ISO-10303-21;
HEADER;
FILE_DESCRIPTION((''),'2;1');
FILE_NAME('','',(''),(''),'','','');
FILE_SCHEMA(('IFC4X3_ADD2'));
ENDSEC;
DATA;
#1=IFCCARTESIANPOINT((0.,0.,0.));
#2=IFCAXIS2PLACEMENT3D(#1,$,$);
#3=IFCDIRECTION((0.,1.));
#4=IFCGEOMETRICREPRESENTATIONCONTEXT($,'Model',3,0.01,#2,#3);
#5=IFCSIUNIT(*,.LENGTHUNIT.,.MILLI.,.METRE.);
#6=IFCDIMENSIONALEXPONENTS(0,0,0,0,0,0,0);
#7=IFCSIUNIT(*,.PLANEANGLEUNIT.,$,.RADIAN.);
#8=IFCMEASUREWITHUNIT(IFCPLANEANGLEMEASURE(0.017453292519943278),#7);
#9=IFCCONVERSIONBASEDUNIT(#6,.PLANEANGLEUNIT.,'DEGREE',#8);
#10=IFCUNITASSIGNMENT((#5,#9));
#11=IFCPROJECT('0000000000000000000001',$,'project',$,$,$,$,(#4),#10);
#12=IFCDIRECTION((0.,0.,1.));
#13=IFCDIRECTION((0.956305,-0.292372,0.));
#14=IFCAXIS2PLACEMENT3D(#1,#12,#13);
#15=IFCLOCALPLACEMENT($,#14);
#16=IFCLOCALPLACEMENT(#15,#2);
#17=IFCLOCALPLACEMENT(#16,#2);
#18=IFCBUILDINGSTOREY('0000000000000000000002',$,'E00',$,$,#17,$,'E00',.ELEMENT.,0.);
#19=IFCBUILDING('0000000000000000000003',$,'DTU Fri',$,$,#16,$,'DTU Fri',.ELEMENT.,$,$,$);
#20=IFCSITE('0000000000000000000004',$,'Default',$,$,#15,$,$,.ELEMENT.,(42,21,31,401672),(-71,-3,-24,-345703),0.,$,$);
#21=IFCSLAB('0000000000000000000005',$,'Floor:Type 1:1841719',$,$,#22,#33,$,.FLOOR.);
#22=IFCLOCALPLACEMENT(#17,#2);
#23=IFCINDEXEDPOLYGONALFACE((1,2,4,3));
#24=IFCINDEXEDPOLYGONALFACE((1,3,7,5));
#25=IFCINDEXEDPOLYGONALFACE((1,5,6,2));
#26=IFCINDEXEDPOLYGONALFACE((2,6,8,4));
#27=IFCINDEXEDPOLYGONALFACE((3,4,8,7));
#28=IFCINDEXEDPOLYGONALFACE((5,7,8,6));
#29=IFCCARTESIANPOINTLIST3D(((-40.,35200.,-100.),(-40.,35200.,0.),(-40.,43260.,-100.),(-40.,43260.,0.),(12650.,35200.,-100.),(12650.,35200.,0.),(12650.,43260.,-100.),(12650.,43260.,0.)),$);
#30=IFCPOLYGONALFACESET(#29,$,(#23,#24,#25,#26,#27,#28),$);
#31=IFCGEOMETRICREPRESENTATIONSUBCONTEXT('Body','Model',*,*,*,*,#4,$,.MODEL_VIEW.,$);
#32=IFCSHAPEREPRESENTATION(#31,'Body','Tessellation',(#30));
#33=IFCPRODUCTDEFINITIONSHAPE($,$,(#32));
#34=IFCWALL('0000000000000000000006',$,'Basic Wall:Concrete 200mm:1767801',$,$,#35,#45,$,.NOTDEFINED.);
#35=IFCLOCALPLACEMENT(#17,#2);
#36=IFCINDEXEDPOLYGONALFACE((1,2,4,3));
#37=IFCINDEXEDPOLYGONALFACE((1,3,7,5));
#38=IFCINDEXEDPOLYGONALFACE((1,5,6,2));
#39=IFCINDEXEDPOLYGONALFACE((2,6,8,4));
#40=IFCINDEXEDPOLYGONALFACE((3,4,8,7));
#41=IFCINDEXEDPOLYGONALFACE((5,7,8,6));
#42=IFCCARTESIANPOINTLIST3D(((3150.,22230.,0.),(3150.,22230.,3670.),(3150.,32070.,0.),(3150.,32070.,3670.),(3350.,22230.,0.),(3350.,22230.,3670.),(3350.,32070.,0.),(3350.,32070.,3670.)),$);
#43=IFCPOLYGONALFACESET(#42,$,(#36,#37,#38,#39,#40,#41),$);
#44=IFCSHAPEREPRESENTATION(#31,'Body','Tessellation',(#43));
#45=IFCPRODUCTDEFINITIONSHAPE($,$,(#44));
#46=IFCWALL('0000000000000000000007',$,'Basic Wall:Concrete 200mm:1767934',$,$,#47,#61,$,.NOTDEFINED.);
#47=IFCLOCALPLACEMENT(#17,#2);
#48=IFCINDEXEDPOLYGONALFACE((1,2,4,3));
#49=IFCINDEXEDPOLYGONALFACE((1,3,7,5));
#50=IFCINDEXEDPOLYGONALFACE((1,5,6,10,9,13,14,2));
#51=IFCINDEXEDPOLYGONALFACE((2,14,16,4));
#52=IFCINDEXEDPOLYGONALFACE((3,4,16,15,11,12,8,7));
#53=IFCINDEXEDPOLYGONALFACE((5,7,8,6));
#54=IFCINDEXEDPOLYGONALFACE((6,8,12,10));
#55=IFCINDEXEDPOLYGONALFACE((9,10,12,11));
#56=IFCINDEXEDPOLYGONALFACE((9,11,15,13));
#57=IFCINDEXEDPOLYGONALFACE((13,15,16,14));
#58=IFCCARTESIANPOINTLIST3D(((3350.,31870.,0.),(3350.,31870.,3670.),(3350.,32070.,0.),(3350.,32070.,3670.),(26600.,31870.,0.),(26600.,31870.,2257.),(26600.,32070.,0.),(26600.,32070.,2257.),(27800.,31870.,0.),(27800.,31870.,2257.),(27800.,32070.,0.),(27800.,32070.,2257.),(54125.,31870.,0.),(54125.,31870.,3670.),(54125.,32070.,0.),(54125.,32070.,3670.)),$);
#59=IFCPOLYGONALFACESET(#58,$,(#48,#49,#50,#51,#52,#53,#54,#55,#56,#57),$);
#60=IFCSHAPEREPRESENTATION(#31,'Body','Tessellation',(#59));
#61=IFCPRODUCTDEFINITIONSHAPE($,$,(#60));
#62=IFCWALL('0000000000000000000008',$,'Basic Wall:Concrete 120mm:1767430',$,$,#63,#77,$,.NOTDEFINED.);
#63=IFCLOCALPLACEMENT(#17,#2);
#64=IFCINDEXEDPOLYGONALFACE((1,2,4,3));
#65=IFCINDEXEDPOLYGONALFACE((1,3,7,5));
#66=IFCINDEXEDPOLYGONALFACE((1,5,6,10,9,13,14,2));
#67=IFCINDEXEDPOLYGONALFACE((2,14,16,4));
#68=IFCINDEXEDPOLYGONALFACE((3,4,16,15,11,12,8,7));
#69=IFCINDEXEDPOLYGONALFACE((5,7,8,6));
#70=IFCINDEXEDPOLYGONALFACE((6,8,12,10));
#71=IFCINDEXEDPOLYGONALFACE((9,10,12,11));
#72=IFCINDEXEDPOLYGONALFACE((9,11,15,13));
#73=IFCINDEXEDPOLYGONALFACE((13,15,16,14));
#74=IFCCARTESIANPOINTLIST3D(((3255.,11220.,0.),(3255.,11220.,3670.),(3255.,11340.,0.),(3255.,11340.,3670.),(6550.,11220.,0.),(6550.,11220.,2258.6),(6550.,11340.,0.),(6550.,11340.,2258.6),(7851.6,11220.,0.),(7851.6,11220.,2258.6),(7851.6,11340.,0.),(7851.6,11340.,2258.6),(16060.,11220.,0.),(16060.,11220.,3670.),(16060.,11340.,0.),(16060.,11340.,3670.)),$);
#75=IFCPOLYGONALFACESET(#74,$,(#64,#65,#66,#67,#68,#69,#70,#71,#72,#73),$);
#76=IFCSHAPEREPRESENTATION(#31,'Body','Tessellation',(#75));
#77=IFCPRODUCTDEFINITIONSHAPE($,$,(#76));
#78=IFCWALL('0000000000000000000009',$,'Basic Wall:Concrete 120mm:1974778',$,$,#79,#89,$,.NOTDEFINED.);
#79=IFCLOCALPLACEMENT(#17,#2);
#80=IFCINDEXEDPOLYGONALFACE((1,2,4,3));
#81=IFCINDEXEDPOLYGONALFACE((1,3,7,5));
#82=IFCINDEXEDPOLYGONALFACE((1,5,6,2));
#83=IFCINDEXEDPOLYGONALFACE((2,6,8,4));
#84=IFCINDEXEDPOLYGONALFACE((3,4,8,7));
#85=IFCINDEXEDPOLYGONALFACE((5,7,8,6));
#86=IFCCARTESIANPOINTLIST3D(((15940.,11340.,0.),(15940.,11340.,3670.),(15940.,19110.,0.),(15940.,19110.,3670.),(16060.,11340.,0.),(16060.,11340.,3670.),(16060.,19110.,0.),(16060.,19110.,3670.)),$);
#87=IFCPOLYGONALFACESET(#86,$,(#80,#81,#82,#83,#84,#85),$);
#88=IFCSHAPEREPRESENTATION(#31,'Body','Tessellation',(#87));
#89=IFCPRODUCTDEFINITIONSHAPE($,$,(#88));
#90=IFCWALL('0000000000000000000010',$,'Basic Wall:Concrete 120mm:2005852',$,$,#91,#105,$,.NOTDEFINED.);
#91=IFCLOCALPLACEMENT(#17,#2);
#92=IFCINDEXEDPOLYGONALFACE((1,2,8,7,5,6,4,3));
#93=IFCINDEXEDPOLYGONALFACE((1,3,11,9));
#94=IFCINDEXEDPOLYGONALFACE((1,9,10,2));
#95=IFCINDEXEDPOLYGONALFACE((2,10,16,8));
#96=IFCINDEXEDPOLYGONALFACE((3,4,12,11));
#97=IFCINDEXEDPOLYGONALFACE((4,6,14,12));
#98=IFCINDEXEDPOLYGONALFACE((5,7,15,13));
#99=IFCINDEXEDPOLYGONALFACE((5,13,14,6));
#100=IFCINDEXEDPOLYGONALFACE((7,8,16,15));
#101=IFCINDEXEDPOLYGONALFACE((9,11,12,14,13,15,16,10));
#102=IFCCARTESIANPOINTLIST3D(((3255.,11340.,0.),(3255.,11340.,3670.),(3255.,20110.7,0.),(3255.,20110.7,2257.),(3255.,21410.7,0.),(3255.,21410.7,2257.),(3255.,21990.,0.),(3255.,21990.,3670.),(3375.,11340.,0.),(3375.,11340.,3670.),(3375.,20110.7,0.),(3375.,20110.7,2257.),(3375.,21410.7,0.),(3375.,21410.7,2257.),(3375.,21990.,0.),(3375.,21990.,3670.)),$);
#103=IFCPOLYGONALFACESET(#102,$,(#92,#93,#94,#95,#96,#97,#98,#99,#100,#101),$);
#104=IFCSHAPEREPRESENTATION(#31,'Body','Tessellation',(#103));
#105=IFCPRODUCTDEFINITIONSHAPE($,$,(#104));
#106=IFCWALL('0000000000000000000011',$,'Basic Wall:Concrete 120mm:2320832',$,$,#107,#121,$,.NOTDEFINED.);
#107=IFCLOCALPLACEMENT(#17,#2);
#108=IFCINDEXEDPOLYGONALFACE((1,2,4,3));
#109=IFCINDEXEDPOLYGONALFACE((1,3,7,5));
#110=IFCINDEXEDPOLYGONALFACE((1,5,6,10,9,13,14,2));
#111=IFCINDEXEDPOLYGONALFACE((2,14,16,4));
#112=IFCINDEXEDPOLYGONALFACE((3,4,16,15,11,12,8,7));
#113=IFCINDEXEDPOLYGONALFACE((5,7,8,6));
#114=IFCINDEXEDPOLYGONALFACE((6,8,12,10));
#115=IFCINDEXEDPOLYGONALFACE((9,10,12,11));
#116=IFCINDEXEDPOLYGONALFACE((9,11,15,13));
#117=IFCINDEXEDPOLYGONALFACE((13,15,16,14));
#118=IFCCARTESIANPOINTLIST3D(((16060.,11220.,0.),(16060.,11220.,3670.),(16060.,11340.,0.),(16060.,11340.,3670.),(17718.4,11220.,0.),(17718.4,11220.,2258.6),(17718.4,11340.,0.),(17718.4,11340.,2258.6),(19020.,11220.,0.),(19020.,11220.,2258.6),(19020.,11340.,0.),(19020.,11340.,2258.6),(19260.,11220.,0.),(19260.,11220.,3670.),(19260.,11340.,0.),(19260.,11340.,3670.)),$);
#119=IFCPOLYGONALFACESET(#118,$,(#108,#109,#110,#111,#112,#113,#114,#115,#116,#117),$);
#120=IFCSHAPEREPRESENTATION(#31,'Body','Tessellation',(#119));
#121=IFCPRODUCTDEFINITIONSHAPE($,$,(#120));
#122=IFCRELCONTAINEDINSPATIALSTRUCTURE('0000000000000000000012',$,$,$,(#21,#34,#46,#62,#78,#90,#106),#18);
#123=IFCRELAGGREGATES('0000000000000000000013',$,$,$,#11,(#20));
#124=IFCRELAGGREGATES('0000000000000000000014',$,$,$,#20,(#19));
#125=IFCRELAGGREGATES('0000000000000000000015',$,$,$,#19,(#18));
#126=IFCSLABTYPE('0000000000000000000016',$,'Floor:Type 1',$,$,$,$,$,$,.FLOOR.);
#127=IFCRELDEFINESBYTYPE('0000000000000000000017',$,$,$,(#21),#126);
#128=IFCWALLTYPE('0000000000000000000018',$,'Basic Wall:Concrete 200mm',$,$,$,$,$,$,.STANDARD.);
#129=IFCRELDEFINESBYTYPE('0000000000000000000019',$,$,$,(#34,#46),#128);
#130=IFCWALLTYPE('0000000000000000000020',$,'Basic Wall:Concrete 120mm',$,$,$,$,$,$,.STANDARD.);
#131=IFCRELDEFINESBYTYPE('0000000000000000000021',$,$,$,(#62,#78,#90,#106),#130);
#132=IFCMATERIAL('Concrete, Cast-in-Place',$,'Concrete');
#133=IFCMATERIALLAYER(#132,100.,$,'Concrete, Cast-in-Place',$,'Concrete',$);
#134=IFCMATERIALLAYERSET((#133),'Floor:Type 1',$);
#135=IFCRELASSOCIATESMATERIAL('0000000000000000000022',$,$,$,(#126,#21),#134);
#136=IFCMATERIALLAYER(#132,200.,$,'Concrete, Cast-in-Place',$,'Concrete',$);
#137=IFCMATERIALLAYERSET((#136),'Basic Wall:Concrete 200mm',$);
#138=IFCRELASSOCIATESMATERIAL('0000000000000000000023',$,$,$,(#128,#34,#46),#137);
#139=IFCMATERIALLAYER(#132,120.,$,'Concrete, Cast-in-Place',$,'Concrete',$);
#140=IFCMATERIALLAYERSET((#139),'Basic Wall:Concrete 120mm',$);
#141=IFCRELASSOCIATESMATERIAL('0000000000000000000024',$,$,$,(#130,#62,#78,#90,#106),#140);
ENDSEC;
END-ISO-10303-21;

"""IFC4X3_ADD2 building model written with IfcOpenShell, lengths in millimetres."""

from ifc_helpers import new_model, entity, si_unit, converted_unit, direction, frame, frame_2d, origin, place, context, subcontext, project, spatial, rectangle, extrude, material, layer, layer_set, layer_usage, type_object, element, save


model = new_model("IFC4X3_ADD2")

# Units and contexts
model_context = context("Model", 3, precision=0.01, world=origin(), true_north=direction((0.0, 1.0)))
body_context = subcontext(model_context, "Body", "Model", "MODEL_VIEW")
ifc_project = project(units=[si_unit("LENGTHUNIT", "METRE", prefix="MILLI"), converted_unit("PLANEANGLEUNIT", "DEGREE", entity("IfcPlaneAngleMeasure", 0.017453292519943278), si_unit("PLANEANGLEUNIT", "RADIAN"), dimensions=[0, 0, 0, 0, 0, 0, 0])], contexts=[model_context])

# Site, building, storey
site_placement = place(None, frame((0.0, 0.0, 0.0), z_axis=(0.0, 0.0, 1.0), x_axis=(0.956305, -0.292372, 0.0)))
site = spatial("IfcSite", under=ifc_project, at=site_placement, Name="Default", CompositionType="ELEMENT", RefLatitude=(42, 21, 31, 401672), RefLongitude=(-71, -3, -24, -345703), RefElevation=0.0)
building_placement = place(site_placement, origin())
building = spatial("IfcBuilding", under=site, at=building_placement, Name="DTU Fri", LongName="DTU Fri", CompositionType="ELEMENT")
storey_placement = place(building_placement, origin())
storey = spatial("IfcBuildingStorey", under=building, at=storey_placement, Name="E00", LongName="E00", CompositionType="ELEMENT", Elevation=0.0)

# Slab
ifc_material_1 = material(Name="Concrete, Cast-in-Place", Category="Concrete")
ifc_layer_1 = layer(ifc_material_1, 100.0, Name="Concrete, Cast-in-Place", Category="Concrete")
ifc_layer_set_1 = layer_set([ifc_layer_1], Name="Floor:Type 1")
ifc_layer_usage = layer_usage(ifc_layer_set_1, "AXIS3", "POSITIVE", 0.0)
slab_type = type_object("IfcSlabType", Name="Floor:Type 1", PredefinedType="FLOOR", material=ifc_layer_set_1)
slab_1_placement = place(storey_placement, frame((-40.0, 35200.0, -100.0)))
element("IfcSlab", 1, at=slab_1_placement, inside=storey, type_object=slab_type, material=ifc_layer_usage, Name="Floor:Type 1:1841719", PredefinedType="FLOOR", context=body_context, shape_type="SweptSolid", body=[
    extrude(rectangle(XDim=8060.0, YDim=12690.0, at=frame_2d((20875.0, 0.0), x_axis=(0.0, -1.0))), frame((27220.0, 4030.0, 100.0), z_axis=(0.0, 0.0, -1.0), x_axis=(-1.0, 0.0, 0.0)), (0.0, 0.0, 1.0), 100.0),
])

# Wall
ifc_layer_2 = layer(ifc_material_1, 200.0, Name="Concrete, Cast-in-Place", Category="Concrete")
ifc_layer_set_2 = layer_set([ifc_layer_2], Name="Basic Wall:Concrete 200mm")
wall_type_1 = type_object("IfcWallType", Name="Basic Wall:Concrete 200mm", PredefinedType="STANDARD", material=ifc_layer_set_2)
wall_1_placement = place(storey_placement, frame((3250.0, 22230.0, 0.0), z_axis=(0.0, 0.0, 1.0), x_axis=(0.0, 1.0, 0.0)))
element("IfcWall", 2, at=wall_1_placement, inside=storey, type_object=wall_type_1, material=ifc_layer_set_2, Name="Basic Wall:Concrete 200mm:1767801", PredefinedType="NOTDEFINED", context=body_context, shape_type="SweptSolid", body=[
    extrude(rectangle(XDim=9840.0, YDim=200.0, at=frame_2d((4920.0, 0.0), x_axis=(-1.0, 0.0))), origin(), (0.0, 0.0, 1.0), 3670.0),
])

# Walls, openings
wall_2_placement = place(storey_placement, frame((3350.0, 31970.0, 0.0)))
wall_2 = element("IfcWall", 3, at=wall_2_placement, inside=storey, type_object=wall_type_1, material=ifc_layer_set_2, Name="Basic Wall:Concrete 200mm:1767934", PredefinedType="NOTDEFINED", context=body_context, shape_type="SweptSolid", body=[
    extrude(rectangle(XDim=50775.0, YDim=200.0, at=frame_2d((25387.5, 0.0), x_axis=(-1.0, 0.0))), origin(), (0.0, 0.0, 1.0), 3670.0),
])
opening_1_placement = place(wall_2_placement, origin())
element("IfcOpeningElement", 4, at=opening_1_placement, cuts=wall_2, PredefinedType="OPENING", context=body_context, shape_type="SweptSolid", body=[
    extrude(rectangle(XDim=2257.0, YDim=1200.0, at=frame_2d((0.0, 0.0), x_axis=(0.0, 1.0))), frame((23850.0, 100.0, 1128.5), z_axis=(0.0, -1.0, 0.0), x_axis=(1.0, 0.0, 0.0)), (0.0, 0.0, 1.0), 200.0),
])
ifc_layer_3 = layer(ifc_material_1, 120.0, Name="Concrete, Cast-in-Place", Category="Concrete")
ifc_layer_set_3 = layer_set([ifc_layer_3], Name="Basic Wall:Concrete 120mm")
wall_type_2 = type_object("IfcWallType", Name="Basic Wall:Concrete 120mm", PredefinedType="STANDARD", material=ifc_layer_set_3)
wall_3_placement = place(storey_placement, frame((3255.0, 11280.0, 0.0)))
wall_3 = element("IfcWall", 5, at=wall_3_placement, inside=storey, type_object=wall_type_2, material=ifc_layer_set_3, Name="Basic Wall:Concrete 120mm:1767430", PredefinedType="NOTDEFINED", context=body_context, shape_type="SweptSolid", body=[
    extrude(rectangle(XDim=12805.0, YDim=120.0, at=frame_2d((6402.5, 0.0), x_axis=(-1.0, 0.0))), origin(), (0.0, 0.0, 1.0), 3670.0),
])
opening_2_placement = place(wall_3_placement, origin())
element("IfcOpeningElement", 6, at=opening_2_placement, cuts=wall_3, PredefinedType="OPENING", context=body_context, shape_type="SweptSolid", body=[
    extrude(rectangle(XDim=2258.6, YDim=1301.6, at=frame_2d((0.0, 0.0), x_axis=(0.0, 1.0))), frame((3945.8, 60.0, 1129.3), z_axis=(0.0, -1.0, 0.0), x_axis=(1.0, 0.0, 0.0)), (0.0, 0.0, 1.0), 120.0),
])

# Wall
wall_4_placement = place(storey_placement, frame((16000.0, 11340.0, 0.0), z_axis=(0.0, 0.0, 1.0), x_axis=(0.0, 1.0, 0.0)))
element("IfcWall", 7, at=wall_4_placement, inside=storey, type_object=wall_type_2, material=ifc_layer_set_3, Name="Basic Wall:Concrete 120mm:1974778", PredefinedType="NOTDEFINED", context=body_context, shape_type="SweptSolid", body=[
    extrude(rectangle(XDim=7770.0, YDim=120.0, at=frame_2d((3885.0, 0.0), x_axis=(-1.0, 0.0))), origin(), (0.0, 0.0, 1.0), 3670.0),
])

# Walls, openings
wall_5_placement = place(storey_placement, frame((3315.0, 11340.0, 0.0), z_axis=(0.0, 0.0, 1.0), x_axis=(0.0, 1.0, 0.0)))
wall_5 = element("IfcWall", 8, at=wall_5_placement, inside=storey, type_object=wall_type_2, material=ifc_layer_set_3, Name="Basic Wall:Concrete 120mm:2005852", PredefinedType="NOTDEFINED", context=body_context, shape_type="SweptSolid", body=[
    extrude(rectangle(XDim=10650.0, YDim=120.0, at=frame_2d((5325.0, 0.0), x_axis=(-1.0, 0.0))), origin(), (0.0, 0.0, 1.0), 3670.0),
])
opening_3_placement = place(wall_5_placement, origin())
element("IfcOpeningElement", 9, at=opening_3_placement, cuts=wall_5, PredefinedType="OPENING", context=body_context, shape_type="SweptSolid", body=[
    extrude(rectangle(XDim=2257.0, YDim=1300.0, at=frame_2d((0.0, 0.0), x_axis=(0.0, 1.0))), frame((9420.7, 60.0, 1128.5), z_axis=(0.0, -1.0, 0.0), x_axis=(1.0, 0.0, 0.0)), (0.0, 0.0, 1.0), 120.0),
])
wall_6_placement = place(storey_placement, frame((16060.0, 11280.0, 0.0)))
wall_6 = element("IfcWall", 10, at=wall_6_placement, inside=storey, type_object=wall_type_2, material=ifc_layer_set_3, Name="Basic Wall:Concrete 120mm:2320832", PredefinedType="NOTDEFINED", context=body_context, shape_type="SweptSolid", body=[
    extrude(rectangle(XDim=3200.0, YDim=120.0, at=frame_2d((1600.0, 0.0), x_axis=(-1.0, 0.0))), origin(), (0.0, 0.0, 1.0), 3670.0),
])
opening_4_placement = place(wall_6_placement, origin())
element("IfcOpeningElement", 11, at=opening_4_placement, cuts=wall_6, PredefinedType="OPENING", context=body_context, shape_type="SweptSolid", body=[
    extrude(rectangle(XDim=2258.6, YDim=1301.6, at=frame_2d((0.0, 0.0), x_axis=(1.0, 0.0))), frame((2309.2, 60.0, 1129.3), z_axis=(0.0, -1.0, 0.0), x_axis=(0.0, 0.0, 1.0)), (0.0, 0.0, 1.0), 120.0),
])

save(model, "model.ifc")
